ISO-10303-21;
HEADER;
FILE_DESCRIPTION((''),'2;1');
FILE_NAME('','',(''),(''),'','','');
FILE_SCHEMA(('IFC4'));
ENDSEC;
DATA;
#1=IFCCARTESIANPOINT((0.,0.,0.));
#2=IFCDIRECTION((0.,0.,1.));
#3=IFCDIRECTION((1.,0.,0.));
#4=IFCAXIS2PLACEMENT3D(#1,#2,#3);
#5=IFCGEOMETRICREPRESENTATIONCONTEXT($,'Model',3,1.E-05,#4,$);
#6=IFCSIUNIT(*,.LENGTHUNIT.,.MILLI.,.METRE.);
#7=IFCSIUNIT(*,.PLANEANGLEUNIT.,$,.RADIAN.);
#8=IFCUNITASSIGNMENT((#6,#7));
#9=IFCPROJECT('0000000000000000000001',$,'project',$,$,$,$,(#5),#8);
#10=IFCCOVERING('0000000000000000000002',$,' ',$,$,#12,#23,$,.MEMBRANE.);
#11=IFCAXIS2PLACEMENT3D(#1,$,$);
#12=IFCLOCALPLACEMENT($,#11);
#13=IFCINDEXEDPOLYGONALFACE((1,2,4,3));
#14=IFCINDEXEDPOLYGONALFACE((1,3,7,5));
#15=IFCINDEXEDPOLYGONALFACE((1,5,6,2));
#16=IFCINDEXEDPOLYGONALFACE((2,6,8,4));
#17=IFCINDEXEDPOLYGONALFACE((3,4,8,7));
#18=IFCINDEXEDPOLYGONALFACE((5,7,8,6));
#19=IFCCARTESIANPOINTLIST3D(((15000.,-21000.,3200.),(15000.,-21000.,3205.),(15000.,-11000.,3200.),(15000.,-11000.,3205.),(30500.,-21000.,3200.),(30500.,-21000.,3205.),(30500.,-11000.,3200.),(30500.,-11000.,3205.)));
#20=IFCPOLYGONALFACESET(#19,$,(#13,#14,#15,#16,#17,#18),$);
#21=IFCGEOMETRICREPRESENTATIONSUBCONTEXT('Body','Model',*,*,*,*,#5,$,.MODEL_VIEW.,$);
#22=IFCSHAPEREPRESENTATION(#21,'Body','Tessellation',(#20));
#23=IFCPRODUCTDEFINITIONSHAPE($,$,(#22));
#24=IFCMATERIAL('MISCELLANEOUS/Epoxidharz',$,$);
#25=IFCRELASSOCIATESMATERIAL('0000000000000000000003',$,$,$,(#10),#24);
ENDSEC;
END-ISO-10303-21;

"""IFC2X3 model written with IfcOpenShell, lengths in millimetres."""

from ifc_helpers import new_model, si_unit, frame, origin_with_axes, place, context, subcontext, project, polyline, outline, extrude, material, element, save


model = new_model("IFC2X3")

# Units and contexts
model_context = context("Model", 3, precision=1e-05, world=origin_with_axes())
body_context = subcontext(model_context, "Body", "Model", "MODEL_VIEW")
ifc_project = project(units=[si_unit("LENGTHUNIT", "METRE", prefix="MILLI"), si_unit("PLANEANGLEUNIT", "RADIAN")], contexts=[model_context])

# Covering
ifc_material = material(Name="MISCELLANEOUS/Epoxidharz")
placement_1 = place(None, origin_with_axes())
placement_2 = place(placement_1, origin_with_axes())
placement_3 = place(placement_2, origin_with_axes())
covering_placement = place(placement_3, frame((30500.0, -11000.0, 3202.5), z_axis=(0.0, 0.0, 1.0), x_axis=(-1.0, 0.0, 0.0)))
element("IfcCovering", 1, at=covering_placement, material=ifc_material, Name=" ", PredefinedType="MEMBRANE", context=body_context, shape_type="SweptSolid", body=[
    extrude(outline(polyline([(0.0, 0.0), (15500.0, 0.0), (15500.0, 10000.0), (0.0, 10000.0), (0.0, 0.0)])), frame((0.0, 0.0, -2.5), z_axis=(0.0, 0.0, 1.0), x_axis=(1.0, 0.0, 0.0)), (0.0, 0.0, 1.0), 5.0),
])

save(model, "model.ifc")
